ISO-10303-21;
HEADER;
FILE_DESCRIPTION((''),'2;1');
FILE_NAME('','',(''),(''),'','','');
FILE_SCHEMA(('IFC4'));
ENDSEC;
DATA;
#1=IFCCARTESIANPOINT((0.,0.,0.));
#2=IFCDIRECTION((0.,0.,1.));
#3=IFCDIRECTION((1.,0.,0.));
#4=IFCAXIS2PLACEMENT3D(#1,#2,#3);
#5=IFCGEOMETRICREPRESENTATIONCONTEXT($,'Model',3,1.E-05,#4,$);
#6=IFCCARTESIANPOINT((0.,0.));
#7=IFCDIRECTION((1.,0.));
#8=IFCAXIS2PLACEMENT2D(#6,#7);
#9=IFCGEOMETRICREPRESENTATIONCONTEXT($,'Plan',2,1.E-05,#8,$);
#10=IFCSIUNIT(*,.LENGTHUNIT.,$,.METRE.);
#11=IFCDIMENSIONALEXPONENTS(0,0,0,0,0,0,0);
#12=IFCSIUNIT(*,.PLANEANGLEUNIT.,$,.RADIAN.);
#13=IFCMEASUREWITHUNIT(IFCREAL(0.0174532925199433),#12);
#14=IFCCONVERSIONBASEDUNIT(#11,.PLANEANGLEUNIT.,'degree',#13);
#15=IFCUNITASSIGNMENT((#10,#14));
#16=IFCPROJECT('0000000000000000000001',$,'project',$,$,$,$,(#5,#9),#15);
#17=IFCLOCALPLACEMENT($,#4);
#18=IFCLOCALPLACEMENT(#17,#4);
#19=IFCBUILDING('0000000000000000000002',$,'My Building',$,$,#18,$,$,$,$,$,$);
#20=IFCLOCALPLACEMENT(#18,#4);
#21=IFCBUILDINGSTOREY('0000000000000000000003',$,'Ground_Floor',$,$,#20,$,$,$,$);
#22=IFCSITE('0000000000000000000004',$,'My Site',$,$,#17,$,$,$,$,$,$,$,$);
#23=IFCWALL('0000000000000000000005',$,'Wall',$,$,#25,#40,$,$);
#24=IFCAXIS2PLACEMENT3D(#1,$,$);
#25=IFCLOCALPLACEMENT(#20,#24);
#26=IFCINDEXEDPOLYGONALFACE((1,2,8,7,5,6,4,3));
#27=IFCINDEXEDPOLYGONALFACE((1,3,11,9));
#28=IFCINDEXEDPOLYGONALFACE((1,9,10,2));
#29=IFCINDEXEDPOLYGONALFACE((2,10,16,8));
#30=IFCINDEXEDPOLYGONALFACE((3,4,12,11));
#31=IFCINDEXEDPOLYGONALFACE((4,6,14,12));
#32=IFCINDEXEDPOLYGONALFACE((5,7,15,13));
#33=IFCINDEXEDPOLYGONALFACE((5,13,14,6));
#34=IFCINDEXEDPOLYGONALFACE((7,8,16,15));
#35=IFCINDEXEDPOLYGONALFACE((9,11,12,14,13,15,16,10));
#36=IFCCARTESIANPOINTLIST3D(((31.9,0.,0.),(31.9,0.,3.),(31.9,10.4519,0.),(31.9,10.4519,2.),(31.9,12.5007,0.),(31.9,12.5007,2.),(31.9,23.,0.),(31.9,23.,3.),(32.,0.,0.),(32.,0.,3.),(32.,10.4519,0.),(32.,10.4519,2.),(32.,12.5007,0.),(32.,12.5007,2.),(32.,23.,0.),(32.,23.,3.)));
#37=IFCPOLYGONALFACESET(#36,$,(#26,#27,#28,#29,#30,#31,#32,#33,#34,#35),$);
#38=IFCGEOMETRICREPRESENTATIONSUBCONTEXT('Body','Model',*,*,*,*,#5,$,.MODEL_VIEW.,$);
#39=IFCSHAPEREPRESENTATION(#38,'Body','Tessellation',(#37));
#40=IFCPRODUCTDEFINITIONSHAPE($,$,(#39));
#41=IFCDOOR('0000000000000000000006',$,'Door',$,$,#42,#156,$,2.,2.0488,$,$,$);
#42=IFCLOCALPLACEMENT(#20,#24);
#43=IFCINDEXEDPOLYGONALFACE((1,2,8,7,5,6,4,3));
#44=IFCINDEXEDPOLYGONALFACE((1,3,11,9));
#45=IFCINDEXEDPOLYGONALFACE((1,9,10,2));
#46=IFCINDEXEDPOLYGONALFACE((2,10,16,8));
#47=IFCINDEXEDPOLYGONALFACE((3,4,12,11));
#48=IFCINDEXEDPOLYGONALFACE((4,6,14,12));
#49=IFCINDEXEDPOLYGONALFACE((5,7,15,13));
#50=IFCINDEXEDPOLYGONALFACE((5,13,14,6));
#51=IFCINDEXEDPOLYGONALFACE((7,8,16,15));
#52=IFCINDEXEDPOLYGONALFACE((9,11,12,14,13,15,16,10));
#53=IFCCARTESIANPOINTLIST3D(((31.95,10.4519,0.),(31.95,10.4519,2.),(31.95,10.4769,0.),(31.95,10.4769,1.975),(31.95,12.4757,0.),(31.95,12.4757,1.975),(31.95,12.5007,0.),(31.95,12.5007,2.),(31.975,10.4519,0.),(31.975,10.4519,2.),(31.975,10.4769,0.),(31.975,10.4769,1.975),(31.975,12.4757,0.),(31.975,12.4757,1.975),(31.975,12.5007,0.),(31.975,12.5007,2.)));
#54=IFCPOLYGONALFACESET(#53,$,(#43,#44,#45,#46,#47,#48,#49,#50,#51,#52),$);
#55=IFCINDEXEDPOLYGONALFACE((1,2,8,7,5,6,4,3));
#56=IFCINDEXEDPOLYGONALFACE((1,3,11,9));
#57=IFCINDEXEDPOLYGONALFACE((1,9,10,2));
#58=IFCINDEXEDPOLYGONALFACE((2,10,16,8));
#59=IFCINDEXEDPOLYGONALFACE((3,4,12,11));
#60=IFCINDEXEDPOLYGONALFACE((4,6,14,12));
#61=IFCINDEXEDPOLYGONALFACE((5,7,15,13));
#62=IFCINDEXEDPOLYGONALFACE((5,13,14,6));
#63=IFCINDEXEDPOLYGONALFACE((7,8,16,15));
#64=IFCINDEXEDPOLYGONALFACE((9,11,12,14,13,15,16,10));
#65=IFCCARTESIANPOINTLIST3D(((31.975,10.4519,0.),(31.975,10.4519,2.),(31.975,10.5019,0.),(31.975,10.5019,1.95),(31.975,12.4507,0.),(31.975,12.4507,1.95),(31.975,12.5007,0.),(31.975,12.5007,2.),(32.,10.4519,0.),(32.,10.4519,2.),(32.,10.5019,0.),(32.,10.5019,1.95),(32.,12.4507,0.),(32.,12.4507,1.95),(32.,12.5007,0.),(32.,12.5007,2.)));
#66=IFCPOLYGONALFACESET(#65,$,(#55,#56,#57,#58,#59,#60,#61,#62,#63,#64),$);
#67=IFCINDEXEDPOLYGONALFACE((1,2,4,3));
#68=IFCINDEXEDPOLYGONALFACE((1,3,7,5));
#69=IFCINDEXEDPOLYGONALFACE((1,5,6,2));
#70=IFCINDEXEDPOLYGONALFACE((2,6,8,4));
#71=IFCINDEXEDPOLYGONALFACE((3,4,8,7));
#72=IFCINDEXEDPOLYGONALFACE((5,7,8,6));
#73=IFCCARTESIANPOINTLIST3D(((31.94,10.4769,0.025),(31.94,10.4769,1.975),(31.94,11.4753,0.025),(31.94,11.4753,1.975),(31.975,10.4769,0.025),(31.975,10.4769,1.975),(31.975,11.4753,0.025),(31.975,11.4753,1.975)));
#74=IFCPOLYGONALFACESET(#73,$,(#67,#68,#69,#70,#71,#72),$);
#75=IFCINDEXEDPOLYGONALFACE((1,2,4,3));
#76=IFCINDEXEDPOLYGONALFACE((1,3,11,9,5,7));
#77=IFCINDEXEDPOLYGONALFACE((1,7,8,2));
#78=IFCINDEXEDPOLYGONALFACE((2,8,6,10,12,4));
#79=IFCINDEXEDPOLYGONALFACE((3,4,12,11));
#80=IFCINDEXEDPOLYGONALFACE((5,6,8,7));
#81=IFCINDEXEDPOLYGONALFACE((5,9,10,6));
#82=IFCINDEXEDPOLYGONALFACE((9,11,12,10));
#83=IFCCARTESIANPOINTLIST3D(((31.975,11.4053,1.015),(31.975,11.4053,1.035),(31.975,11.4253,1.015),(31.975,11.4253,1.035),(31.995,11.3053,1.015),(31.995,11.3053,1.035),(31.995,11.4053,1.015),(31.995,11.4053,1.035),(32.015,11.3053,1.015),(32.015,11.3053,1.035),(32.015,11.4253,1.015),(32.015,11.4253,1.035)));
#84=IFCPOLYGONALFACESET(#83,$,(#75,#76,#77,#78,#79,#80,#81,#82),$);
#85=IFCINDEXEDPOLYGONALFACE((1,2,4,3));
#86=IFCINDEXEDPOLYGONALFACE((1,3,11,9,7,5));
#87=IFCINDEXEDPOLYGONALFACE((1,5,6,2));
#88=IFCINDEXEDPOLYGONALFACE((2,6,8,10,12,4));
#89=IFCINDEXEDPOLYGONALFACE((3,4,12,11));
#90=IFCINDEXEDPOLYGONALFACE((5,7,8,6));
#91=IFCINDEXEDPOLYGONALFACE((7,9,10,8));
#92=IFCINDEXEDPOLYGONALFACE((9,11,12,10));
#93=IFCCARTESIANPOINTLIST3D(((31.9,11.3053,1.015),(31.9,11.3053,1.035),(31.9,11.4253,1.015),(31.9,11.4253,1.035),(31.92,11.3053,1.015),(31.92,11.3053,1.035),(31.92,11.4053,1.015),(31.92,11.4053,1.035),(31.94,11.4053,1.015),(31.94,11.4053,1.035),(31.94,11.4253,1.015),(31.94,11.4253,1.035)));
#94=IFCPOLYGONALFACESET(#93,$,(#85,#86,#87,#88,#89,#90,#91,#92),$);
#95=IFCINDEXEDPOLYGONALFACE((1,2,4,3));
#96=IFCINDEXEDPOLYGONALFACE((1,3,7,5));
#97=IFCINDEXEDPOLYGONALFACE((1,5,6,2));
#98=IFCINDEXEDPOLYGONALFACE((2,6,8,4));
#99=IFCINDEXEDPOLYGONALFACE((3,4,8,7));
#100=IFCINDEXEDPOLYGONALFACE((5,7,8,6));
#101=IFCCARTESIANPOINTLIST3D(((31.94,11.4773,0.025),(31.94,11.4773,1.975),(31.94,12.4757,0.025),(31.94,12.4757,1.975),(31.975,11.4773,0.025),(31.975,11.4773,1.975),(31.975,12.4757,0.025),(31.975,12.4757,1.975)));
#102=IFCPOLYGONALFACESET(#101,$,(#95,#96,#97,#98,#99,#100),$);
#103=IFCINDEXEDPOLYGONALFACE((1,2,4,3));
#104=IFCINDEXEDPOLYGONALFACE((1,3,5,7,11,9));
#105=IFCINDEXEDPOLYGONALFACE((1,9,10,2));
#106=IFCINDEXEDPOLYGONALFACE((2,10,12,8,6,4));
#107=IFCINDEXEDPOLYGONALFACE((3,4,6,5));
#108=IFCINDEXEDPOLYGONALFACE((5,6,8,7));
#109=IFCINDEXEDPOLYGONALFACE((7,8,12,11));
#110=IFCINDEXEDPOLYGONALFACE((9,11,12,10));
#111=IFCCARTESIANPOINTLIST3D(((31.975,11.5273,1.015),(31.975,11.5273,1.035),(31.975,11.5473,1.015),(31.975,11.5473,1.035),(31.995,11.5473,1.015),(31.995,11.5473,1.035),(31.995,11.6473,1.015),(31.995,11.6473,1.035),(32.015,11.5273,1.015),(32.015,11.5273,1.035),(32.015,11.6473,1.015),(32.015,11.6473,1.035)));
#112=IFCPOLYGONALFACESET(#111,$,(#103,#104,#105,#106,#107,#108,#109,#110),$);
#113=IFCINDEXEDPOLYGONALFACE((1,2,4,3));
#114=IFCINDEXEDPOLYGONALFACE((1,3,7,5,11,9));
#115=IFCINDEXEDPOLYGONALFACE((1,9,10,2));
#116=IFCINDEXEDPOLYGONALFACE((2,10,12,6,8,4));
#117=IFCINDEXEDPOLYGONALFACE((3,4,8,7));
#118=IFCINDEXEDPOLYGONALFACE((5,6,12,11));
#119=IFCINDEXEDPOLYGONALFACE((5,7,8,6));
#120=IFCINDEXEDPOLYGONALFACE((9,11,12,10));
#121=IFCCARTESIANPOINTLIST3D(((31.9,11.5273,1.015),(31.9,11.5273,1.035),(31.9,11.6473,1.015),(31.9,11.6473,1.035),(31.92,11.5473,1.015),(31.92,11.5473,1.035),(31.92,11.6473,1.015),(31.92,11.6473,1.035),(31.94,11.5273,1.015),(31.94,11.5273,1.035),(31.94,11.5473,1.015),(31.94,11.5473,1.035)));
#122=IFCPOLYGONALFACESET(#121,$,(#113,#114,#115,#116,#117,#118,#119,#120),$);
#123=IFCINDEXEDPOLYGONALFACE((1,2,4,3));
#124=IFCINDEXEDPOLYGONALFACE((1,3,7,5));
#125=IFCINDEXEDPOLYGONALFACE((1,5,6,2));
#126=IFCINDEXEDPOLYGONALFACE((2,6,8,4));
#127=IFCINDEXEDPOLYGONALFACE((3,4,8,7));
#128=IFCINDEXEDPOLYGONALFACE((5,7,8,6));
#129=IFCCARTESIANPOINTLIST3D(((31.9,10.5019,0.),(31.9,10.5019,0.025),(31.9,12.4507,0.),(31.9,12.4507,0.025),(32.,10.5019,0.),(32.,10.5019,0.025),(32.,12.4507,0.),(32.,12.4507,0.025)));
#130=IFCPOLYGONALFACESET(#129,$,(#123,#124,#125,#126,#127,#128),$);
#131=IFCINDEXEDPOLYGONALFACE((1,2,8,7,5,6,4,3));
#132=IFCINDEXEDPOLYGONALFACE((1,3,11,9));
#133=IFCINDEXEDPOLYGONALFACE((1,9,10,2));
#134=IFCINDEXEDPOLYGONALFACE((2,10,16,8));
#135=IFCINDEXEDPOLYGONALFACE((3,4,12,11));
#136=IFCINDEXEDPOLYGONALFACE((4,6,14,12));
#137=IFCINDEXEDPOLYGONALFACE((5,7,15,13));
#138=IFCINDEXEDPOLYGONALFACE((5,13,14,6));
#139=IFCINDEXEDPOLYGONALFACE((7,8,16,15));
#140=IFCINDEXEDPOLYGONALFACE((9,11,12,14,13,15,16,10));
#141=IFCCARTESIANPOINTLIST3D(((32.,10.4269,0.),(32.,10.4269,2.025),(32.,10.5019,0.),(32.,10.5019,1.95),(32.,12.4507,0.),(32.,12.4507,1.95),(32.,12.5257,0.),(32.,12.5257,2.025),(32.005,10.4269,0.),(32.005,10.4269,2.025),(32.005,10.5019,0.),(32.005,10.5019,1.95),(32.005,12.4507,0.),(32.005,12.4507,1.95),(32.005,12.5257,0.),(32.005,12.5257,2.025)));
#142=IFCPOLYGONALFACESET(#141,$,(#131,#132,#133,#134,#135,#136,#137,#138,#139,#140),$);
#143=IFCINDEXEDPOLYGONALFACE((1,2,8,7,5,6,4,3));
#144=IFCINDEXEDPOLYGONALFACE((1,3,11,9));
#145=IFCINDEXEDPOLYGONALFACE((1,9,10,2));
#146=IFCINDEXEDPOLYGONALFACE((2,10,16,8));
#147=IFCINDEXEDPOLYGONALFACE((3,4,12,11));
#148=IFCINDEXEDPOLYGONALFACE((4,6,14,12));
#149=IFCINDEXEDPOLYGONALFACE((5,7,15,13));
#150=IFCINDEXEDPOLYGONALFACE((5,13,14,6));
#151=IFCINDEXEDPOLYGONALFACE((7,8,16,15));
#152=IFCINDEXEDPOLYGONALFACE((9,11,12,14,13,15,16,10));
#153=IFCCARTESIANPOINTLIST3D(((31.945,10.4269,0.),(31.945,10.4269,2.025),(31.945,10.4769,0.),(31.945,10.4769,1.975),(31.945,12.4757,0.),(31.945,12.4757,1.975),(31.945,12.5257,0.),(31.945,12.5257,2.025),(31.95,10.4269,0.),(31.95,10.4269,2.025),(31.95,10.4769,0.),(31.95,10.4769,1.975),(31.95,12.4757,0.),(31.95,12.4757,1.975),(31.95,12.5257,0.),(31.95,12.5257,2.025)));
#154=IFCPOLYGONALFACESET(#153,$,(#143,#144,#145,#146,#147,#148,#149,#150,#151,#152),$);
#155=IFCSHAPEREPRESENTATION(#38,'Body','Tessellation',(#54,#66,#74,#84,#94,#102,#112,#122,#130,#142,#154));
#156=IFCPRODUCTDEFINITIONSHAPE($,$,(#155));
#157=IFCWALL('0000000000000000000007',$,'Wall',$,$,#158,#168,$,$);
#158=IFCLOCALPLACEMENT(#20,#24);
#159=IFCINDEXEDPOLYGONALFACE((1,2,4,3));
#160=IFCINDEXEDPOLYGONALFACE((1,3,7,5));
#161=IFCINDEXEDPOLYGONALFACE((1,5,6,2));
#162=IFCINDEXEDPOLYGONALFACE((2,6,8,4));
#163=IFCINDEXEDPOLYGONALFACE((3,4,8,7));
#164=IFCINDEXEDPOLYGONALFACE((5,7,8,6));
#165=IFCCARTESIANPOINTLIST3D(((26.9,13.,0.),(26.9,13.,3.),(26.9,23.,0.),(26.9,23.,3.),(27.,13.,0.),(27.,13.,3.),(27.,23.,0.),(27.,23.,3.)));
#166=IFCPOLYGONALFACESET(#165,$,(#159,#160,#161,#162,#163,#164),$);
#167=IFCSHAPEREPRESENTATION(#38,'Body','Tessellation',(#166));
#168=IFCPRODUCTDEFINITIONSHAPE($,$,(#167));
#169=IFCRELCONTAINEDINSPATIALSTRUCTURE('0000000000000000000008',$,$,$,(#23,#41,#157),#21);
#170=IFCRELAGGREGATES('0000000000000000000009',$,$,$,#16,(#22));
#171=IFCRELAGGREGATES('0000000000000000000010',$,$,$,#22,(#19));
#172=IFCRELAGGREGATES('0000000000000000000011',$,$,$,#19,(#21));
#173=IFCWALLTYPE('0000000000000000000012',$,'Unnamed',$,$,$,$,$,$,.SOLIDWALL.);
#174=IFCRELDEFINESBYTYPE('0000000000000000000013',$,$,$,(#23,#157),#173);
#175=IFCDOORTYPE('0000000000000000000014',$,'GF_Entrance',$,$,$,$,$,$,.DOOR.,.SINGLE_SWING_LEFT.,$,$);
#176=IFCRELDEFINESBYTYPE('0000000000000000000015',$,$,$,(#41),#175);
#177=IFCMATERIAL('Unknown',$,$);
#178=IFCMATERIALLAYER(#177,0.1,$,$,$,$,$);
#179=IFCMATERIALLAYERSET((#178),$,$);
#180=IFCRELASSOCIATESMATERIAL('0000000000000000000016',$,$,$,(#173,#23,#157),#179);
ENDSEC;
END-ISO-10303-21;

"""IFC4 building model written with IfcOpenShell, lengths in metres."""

from ifc_helpers import new_model, entity, si_unit, converted_unit, frame, origin_with_axes, origin_2d_with_axis, place, context, subcontext, project, spatial, line, indexed_curve, outline, extrude, shape, source, transform, mapped, material, layer, layer_set, layer_usage, type_object, type_shapes, element, fill, save


model = new_model("IFC4")

# Units and contexts
model_context = context("Model", 3, precision=1e-05, world=origin_with_axes())
plan_context = context("Plan", 2, precision=1e-05, world=origin_2d_with_axis())
body_context_1 = subcontext(model_context, "Body", "Model", "MODEL_VIEW")
body_context_2 = subcontext(plan_context, "Body", "Plan", "PLAN_VIEW")
ifc_project = project(units=[si_unit("LENGTHUNIT", "METRE"), converted_unit("PLANEANGLEUNIT", "degree", entity("IfcReal", 0.0174532925199433), si_unit("PLANEANGLEUNIT", "RADIAN"), dimensions=[0, 0, 0, 0, 0, 0, 0])], contexts=[model_context, plan_context])

# Site, building, storey
site_placement = place(None, origin_with_axes())
site = spatial("IfcSite", under=ifc_project, at=site_placement, Name="My Site")
building_placement = place(site_placement, origin_with_axes())
building = spatial("IfcBuilding", under=site, at=building_placement, Name="My Building")
storey_placement = place(building_placement, origin_with_axes())
storey = spatial("IfcBuildingStorey", under=building, at=storey_placement, Name="Ground_Floor")

# Shared definitions
ifc_material = material(Name="Unknown")
ifc_layer = layer(ifc_material, 0.1)
ifc_layer_set = layer_set([ifc_layer])
wall_type = type_object("IfcWallType", Name="Unnamed", PredefinedType="SOLIDWALL", material=ifc_layer_set)

# Wall, opening, door
ifc_layer_usage_1 = layer_usage(ifc_layer_set, "AXIS2", "POSITIVE", 0.0)
wall_1_placement = place(storey_placement, frame((32.0, 0.0, 0.0), z_axis=(0.0, 0.0, 1.0), x_axis=(0.0, 1.0, 0.0)))
wall_1 = element("IfcWall", 1, at=wall_1_placement, inside=storey, type_object=wall_type, material=ifc_layer_usage_1, Name="Wall", context=body_context_1, shape_type="SweptSolid", body=[
    extrude(outline(indexed_curve([(0.0, 0.0), (0.0, 0.1), (23.0, 0.1), (23.0, 0.0)], segments=[line(1, 2, 3, 4, 1)])), origin_with_axes(), (0.0, 0.0, 1.0), 3.0),
])
shared_shape_1 = source(origin_with_axes(), body_context_1, "Body", "SweptSolid", [
    extrude(outline(indexed_curve([(0.0, 0.0), (2.0488, 0.0), (2.0488, 2.0), (0.0, 2.0)], segments=[line(1, 2, 3, 4, 1)])), frame((0.0, -0.6, 0.0), z_axis=(0.0, -1.0, 0.0), x_axis=(1.0, 0.0, 0.0)), (0.0, 0.0, -1.0), 1.2),
])
opening_1_placement = place(wall_1_placement, frame((10.4519, 0.0, 0.0), z_axis=(0.0, 0.0, 1.0), x_axis=(1.0, 0.0, 0.0)))
opening_1 = element("IfcOpeningElement", 2, at=opening_1_placement, cuts=wall_1, PredefinedType="OPENING", context=body_context_1, shape_type="MappedRepresentation", body=[
    mapped(shared_shape_1, transform((0.0, 0.0, 0.0), x_axis=(1.0, 0.0, 0.0), y_axis=(0.0, 1.0, 0.0), z_axis=(0.0, 0.0, 1.0), scale=1.0)),
])
door_type_1 = type_object("IfcDoorType", Name="GF_Entrance", OperationType="SINGLE_SWING_LEFT", PredefinedType="DOOR")
shared_shape_2 = source(origin_with_axes(), body_context_1, "Body", "SweptSolid", [
    extrude(outline(indexed_curve([(0.0, 0.0), (0.0, 2.0), (2.0488, 2.0), (2.0488, 0.0), (2.0238, 0.0), (2.0238, 1.975), (0.025, 1.975), (0.025, 0.0)], segments=[line(1, 2, 3, 4, 5, 6, 7, 8, 1)])), frame((0.0, 0.025, 0.0), z_axis=(0.0, -1.0, 0.0), x_axis=(1.0, 0.0, 0.0)), (0.0, 0.0, -1.0), 0.025),
    extrude(outline(indexed_curve([(0.0, 0.0), (0.0, 2.0), (2.0488, 2.0), (2.0488, 0.0), (1.9988, 0.0), (1.9988, 1.95), (0.05, 1.95), (0.05, 0.0)], segments=[line(1, 2, 3, 4, 5, 6, 7, 8, 1)])), frame((0.0, 0.0, 0.0), z_axis=(0.0, -1.0, 0.0), x_axis=(1.0, 0.0, 0.0)), (0.0, 0.0, -1.0), 0.025),
    extrude(outline(indexed_curve([(0.0, 0.0), (0.9984, 0.0), (0.9984, 0.035), (0.0, 0.035)], segments=[line(1, 2, 3, 4, 1)])), frame((0.025, 0.025, 0.025), z_axis=(0.0, 0.0, 1.0), x_axis=(1.0, 0.0, 0.0)), (0.0, 0.0, 1.0), 1.95),
    extrude(outline(indexed_curve([(0.0, 0.0), (0.0, -0.04), (-0.12, -0.04), (-0.12, -0.02), (-0.02, -0.02), (-0.02, 0.0)], segments=[line(1, 2, 3, 4, 5, 6, 1)])), frame((0.9734, 0.025, 1.015), z_axis=(0.0, 0.0, 1.0), x_axis=(1.0, 0.0, 0.0)), (0.0, 0.0, 1.0), 0.02),
    extrude(outline(indexed_curve([(0.0, 0.0), (0.0, 0.04), (-0.12, 0.04), (-0.12, 0.02), (-0.02, 0.02), (-0.02, 0.0)], segments=[line(1, 2, 3, 4, 5, 6, 1)])), frame((0.9734, 0.06, 1.015), z_axis=(0.0, 0.0, 1.0), x_axis=(1.0, 0.0, 0.0)), (0.0, 0.0, 1.0), 0.02),
    extrude(outline(indexed_curve([(0.0, 0.0), (-0.9984, 0.0), (-0.9984, 0.035), (0.0, 0.035)], segments=[line(1, 2, 3, 4, 1)])), frame((2.0238, 0.025, 0.025), z_axis=(0.0, 0.0, 1.0), x_axis=(1.0, 0.0, 0.0)), (0.0, 0.0, 1.0), 1.95),
    extrude(outline(indexed_curve([(0.0, 0.0), (0.0, -0.04), (0.12, -0.04), (0.12, -0.02), (0.02, -0.02), (0.02, 0.0)], segments=[line(1, 2, 3, 4, 5, 6, 1)])), frame((1.0754, 0.025, 1.015), z_axis=(0.0, 0.0, 1.0), x_axis=(1.0, 0.0, 0.0)), (0.0, 0.0, 1.0), 0.02),
    extrude(outline(indexed_curve([(0.0, 0.0), (0.0, 0.04), (0.12, 0.04), (0.12, 0.02), (0.02, 0.02), (0.02, 0.0)], segments=[line(1, 2, 3, 4, 5, 6, 1)])), frame((1.0754, 0.06, 1.015), z_axis=(0.0, 0.0, 1.0), x_axis=(1.0, 0.0, 0.0)), (0.0, 0.0, 1.0), 0.02),
    extrude(outline(indexed_curve([(0.0, 0.0), (1.9488, 0.0), (1.9488, 0.1), (0.0, 0.1)], segments=[line(1, 2, 3, 4, 1)])), frame((0.05, 0.0, 0.0), z_axis=(0.0, 0.0, 1.0), x_axis=(1.0, 0.0, 0.0)), (0.0, 0.0, 1.0), 0.025),
    extrude(outline(indexed_curve([(0.0, 0.0), (0.0, 2.025), (2.0988, 2.025), (2.0988, 0.0), (2.0238, 0.0), (2.0238, 1.95), (0.075, 1.95), (0.075, 0.0)], segments=[line(1, 2, 3, 4, 5, 6, 7, 8, 1)])), frame((-0.025, -0.005, 0.0), z_axis=(0.0, -1.0, 0.0), x_axis=(1.0, 0.0, 0.0)), (0.0, 0.0, -1.0), 0.005),
    extrude(outline(indexed_curve([(0.0, 0.0), (0.0, 2.025), (2.0988, 2.025), (2.0988, 0.0), (2.0488, 0.0), (2.0488, 1.975), (0.05, 1.975), (0.05, 0.0)], segments=[line(1, 2, 3, 4, 5, 6, 7, 8, 1)])), frame((-0.025, 0.05, 0.0), z_axis=(0.0, -1.0, 0.0), x_axis=(1.0, 0.0, 0.0)), (0.0, 0.0, -1.0), 0.005),
])
shared_shape_3 = source(origin_with_axes(), body_context_2, "Body", "Curve2D", [
    entity("IfcIndexedPolyCurve", entity("IfcCartesianPointList2D", [[0.0, 0.0], [0.0, 0.05], [0.025, 0.05], [0.025, 0.025], [0.05, 0.025], [0.05, 0.0]]), [entity("IfcLineIndex", [1, 2, 3, 4, 5, 6, 1])]),
    entity("IfcIndexedPolyCurve", entity("IfcCartesianPointList2D", [[2.0488, 0.0], [2.0488, 0.05], [2.0238, 0.05], [2.0238, 0.025], [1.9988, 0.025], [1.9988, 0.0]]), [entity("IfcLineIndex", [1, 2, 3, 4, 5, 6, 1])]),
    entity("IfcTrimmedCurve", entity("IfcEllipse", entity("IfcAxis2Placement2D", entity("IfcCartesianPoint", [0.06, 0.05]), entity("IfcDirection", [1.0, 0.0])), 0.9644, 0.9994), [entity("IfcCartesianPoint", [1.0244, 0.05])], [entity("IfcCartesianPoint", [0.06, 1.0494])], True, "CARTESIAN"),
    entity("IfcIndexedPolyCurve", entity("IfcCartesianPointList2D", [[0.025, 0.05], [0.06, 0.05], [0.06, 1.0494], [0.025, 1.0494]]), [entity("IfcLineIndex", [1, 2, 3, 4, 1])]),
    entity("IfcTrimmedCurve", entity("IfcEllipse", entity("IfcAxis2Placement2D", entity("IfcCartesianPoint", [1.9888, 0.05]), entity("IfcDirection", [1.0, 0.0])), 0.9644, 0.9994), [entity("IfcCartesianPoint", [1.9888, 1.0494])], [entity("IfcCartesianPoint", [1.0244, 0.05])], True, "CARTESIAN"),
    entity("IfcIndexedPolyCurve", entity("IfcCartesianPointList2D", [[2.0238, 0.05], [1.9888, 0.05], [1.9888, 1.0494], [2.0238, 1.0494]]), [entity("IfcLineIndex", [1, 2, 3, 4, 1])]),
])
type_shapes(door_type_1, [shared_shape_2, shared_shape_3])
door_1_placement = place(opening_1_placement, frame((0.0, 0.0, 0.0), z_axis=(0.0, 0.0, 1.0), x_axis=(1.0, 0.0, 0.0)))
door_1 = element("IfcDoor", 3, at=door_1_placement, inside=storey, type_object=door_type_1, Name="Door", OverallHeight=2.0, OverallWidth=2.0488, shapes=[
    shape(body_context_1, "Body", "MappedRepresentation", [mapped(shared_shape_2, transform((0.0, 0.0, 0.0), x_axis=(1.0, 0.0, 0.0), y_axis=(0.0, 1.0, 0.0), z_axis=(0.0, 0.0, 1.0), scale=1.0))]),
    shape(body_context_2, "Body", "MappedRepresentation", [mapped(shared_shape_3, transform((0.0, 0.0, 0.0), x_axis=(1.0, 0.0, 0.0), y_axis=(0.0, 1.0, 0.0), z_axis=(0.0, 0.0, 1.0), scale=1.0))]),
])
fill(opening_1, door_1)

# Wall
ifc_layer_usage_2 = layer_usage(ifc_layer_set, "AXIS2", "POSITIVE", 0.0)
wall_2_placement = place(storey_placement, frame((27.0, 13.0, 0.0), z_axis=(0.0, 0.0, 1.0), x_axis=(0.0, 1.0, 0.0)))
element("IfcWall", 4, at=wall_2_placement, inside=storey, type_object=wall_type, material=ifc_layer_usage_2, Name="Wall", context=body_context_1, shape_type="SweptSolid", body=[
    extrude(outline(indexed_curve([(0.0, 0.0), (0.0, 0.1), (10.0, 0.1), (10.0, 0.0)], segments=[line(1, 2, 3, 4, 1)])), origin_with_axes(), (0.0, 0.0, 1.0), 3.0),
])

save(model, "model.ifc")
